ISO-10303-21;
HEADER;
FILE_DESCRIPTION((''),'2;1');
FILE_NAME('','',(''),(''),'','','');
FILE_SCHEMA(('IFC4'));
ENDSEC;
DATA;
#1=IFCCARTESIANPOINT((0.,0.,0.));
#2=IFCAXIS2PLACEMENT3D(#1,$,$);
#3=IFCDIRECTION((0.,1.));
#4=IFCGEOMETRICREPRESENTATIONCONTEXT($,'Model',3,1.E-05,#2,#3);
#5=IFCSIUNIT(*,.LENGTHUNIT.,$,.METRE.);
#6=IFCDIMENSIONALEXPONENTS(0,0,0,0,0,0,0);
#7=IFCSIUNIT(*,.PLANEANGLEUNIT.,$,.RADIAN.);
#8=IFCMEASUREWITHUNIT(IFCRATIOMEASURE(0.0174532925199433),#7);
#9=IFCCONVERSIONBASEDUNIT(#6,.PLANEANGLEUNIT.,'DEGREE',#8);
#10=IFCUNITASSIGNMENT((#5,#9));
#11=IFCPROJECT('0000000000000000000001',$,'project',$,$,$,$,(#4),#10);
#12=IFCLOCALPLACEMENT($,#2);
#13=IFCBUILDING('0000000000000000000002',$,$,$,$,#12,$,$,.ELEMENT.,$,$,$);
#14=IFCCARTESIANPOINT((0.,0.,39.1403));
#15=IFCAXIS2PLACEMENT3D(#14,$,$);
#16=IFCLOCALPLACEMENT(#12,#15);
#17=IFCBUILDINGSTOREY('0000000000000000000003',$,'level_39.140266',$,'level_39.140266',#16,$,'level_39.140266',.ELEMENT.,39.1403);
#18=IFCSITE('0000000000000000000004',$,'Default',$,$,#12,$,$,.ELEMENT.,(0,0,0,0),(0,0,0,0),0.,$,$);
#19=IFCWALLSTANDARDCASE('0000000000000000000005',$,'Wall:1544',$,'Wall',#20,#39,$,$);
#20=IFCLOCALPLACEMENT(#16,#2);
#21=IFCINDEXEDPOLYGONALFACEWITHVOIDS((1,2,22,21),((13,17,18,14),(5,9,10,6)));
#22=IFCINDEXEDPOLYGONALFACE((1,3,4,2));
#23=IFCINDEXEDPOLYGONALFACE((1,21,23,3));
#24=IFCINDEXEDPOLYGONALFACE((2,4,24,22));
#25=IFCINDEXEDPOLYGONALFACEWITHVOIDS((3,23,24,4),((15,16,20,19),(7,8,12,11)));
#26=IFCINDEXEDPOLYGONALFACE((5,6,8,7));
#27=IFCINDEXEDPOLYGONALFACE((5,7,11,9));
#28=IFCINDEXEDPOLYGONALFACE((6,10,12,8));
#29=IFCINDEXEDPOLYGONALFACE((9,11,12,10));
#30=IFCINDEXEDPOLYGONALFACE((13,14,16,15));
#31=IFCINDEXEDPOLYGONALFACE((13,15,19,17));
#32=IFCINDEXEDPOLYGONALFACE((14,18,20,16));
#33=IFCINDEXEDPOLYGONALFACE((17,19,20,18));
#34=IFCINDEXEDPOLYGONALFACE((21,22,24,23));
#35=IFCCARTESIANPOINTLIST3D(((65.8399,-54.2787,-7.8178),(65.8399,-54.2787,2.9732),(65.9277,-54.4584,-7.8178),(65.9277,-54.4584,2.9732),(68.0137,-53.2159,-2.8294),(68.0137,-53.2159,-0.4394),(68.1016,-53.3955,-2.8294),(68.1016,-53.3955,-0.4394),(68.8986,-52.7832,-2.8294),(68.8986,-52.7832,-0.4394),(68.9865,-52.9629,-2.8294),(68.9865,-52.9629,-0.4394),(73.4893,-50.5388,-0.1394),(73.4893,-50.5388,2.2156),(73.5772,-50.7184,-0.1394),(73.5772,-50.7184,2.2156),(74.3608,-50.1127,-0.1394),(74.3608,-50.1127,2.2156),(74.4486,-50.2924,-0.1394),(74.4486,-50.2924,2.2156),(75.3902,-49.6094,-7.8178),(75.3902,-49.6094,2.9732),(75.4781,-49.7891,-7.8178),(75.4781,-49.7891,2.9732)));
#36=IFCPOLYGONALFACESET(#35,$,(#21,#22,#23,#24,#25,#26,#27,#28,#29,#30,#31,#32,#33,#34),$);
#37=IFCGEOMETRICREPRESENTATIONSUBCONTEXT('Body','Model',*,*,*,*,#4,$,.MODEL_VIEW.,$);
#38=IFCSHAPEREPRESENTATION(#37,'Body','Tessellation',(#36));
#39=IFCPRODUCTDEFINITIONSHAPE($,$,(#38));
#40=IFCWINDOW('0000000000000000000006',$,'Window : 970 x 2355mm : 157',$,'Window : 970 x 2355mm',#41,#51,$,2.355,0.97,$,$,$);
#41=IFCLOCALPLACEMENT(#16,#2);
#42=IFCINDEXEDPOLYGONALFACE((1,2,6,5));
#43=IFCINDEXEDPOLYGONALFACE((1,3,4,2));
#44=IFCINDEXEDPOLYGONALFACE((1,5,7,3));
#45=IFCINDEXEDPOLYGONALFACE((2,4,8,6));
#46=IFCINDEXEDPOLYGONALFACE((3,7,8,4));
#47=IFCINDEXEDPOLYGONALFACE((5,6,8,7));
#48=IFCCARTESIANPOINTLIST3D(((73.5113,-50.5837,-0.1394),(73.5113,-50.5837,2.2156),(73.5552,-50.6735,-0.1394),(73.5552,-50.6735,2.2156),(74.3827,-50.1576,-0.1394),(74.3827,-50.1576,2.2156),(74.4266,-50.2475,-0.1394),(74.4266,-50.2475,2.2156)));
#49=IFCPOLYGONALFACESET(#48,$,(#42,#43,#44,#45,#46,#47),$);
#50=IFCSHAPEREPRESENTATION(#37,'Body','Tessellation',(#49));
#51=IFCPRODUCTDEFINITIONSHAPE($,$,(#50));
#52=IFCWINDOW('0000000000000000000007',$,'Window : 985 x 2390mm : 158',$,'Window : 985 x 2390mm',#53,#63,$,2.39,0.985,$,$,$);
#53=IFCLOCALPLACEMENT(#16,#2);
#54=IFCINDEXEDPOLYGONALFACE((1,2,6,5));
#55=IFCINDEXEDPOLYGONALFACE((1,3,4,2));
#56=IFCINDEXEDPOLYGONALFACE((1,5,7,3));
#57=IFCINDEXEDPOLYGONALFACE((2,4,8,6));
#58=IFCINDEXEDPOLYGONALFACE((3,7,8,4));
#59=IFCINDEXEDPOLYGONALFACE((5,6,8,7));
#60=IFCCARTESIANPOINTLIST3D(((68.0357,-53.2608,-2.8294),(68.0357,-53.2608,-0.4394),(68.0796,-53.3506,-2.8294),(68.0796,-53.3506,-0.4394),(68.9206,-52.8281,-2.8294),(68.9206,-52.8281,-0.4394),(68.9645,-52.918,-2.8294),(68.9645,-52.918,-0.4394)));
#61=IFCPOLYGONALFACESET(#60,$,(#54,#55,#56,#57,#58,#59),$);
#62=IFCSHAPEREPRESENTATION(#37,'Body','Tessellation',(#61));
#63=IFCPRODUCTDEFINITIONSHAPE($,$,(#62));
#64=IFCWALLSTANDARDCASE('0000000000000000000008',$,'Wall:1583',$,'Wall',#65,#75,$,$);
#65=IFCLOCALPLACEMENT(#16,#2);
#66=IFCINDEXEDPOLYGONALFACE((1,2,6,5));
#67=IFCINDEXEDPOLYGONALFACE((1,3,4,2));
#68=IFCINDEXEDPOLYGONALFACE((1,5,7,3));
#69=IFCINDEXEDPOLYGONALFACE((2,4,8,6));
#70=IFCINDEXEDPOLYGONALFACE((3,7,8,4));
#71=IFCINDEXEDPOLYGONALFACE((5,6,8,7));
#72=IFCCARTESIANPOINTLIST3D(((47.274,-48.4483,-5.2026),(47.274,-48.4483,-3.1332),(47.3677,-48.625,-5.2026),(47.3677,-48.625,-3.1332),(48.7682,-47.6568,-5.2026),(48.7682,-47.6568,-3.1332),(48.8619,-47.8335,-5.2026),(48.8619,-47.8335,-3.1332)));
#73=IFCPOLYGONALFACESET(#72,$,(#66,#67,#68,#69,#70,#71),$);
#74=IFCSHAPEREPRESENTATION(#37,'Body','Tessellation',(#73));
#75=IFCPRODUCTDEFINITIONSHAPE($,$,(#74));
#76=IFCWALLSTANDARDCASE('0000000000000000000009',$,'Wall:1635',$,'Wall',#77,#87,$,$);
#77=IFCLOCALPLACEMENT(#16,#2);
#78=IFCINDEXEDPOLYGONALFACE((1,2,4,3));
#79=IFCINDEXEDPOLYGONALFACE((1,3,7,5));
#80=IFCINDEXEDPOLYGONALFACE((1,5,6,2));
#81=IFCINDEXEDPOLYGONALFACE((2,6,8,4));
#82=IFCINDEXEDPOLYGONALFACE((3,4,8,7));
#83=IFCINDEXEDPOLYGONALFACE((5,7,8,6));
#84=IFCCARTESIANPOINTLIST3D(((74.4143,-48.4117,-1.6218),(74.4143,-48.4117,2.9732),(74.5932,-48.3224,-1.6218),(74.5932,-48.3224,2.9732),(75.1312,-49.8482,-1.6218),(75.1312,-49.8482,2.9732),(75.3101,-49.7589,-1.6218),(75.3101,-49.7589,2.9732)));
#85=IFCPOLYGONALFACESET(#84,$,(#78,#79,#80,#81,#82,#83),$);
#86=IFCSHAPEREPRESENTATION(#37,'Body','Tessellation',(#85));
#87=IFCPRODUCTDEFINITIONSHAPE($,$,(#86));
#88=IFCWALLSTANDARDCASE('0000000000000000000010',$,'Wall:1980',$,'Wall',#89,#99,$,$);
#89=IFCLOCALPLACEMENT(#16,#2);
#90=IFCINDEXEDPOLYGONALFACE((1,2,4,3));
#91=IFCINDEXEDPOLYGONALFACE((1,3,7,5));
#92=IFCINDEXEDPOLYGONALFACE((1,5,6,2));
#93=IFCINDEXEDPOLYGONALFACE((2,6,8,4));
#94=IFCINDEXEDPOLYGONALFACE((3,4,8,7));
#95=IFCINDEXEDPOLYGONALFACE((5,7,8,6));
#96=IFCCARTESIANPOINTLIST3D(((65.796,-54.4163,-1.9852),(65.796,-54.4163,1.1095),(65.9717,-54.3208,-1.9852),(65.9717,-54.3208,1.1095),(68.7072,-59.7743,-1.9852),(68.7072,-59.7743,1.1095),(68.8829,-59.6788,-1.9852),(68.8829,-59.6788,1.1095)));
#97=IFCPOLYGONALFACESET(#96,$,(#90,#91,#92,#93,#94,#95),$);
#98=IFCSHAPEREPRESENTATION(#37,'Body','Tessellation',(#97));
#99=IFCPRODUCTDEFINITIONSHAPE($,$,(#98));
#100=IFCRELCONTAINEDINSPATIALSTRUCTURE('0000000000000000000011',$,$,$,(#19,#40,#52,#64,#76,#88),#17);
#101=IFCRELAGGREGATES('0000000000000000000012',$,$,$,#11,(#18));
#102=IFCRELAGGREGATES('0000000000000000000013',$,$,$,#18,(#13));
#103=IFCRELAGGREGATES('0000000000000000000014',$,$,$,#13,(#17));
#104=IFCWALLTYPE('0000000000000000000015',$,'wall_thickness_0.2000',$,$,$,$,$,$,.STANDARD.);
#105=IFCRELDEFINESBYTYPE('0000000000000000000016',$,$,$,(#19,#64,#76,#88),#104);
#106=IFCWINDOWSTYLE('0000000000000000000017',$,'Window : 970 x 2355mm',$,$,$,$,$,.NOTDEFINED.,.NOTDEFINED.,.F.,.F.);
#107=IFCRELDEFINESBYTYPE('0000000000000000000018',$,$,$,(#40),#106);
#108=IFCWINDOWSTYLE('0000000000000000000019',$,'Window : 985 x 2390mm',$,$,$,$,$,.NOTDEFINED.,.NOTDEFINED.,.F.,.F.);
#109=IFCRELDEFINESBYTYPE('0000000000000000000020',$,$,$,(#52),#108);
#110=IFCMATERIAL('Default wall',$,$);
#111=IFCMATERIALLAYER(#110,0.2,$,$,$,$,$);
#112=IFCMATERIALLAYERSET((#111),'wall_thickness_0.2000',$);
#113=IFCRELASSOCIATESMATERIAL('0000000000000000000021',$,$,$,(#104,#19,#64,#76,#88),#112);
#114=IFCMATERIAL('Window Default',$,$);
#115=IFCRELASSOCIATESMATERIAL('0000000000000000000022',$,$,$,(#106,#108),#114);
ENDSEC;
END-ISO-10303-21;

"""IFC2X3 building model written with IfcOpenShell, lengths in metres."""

from ifc_helpers import new_model, entity, si_unit, converted_unit, direction, frame, frame_2d, origin, origin_2d_with_axis, place, context, subcontext, project, spatial, polyline, rectangle, outline, extrude, source, transform, mapped, material, layer, layer_set, layer_usage, type_object, type_shapes, element, fill, save


model = new_model("IFC2X3")

# Units and contexts
model_context = context("Model", 3, precision=1e-05, world=origin(), true_north=direction((0.0, 1.0)))
body_context = subcontext(model_context, "Body", "Model", "MODEL_VIEW")
ifc_project = project(units=[si_unit("LENGTHUNIT", "METRE"), converted_unit("PLANEANGLEUNIT", "DEGREE", entity("IfcRatioMeasure", 0.0174532925199433), si_unit("PLANEANGLEUNIT", "RADIAN"), dimensions=[0, 0, 0, 0, 0, 0, 0])], contexts=[model_context])

# Site, building, storey
placement_1 = place(None, origin())
site = spatial("IfcSite", under=ifc_project, at=placement_1, Name="Default", CompositionType="ELEMENT", RefLatitude=(0, 0, 0, 0), RefLongitude=(0, 0, 0, 0), RefElevation=0.0)
building = spatial("IfcBuilding", under=site, at=placement_1, CompositionType="ELEMENT")
storey_placement = place(placement_1, frame((0.0, 0.0, 39.1403)))
storey = spatial("IfcBuildingStorey", under=building, at=storey_placement, Name="level_39.140266", ObjectType="level_39.140266", LongName="level_39.140266", CompositionType="ELEMENT", Elevation=39.1403)

# Shared definitions
ifc_material_1 = material(Name="Default wall")
ifc_layer = layer(ifc_material_1, 0.2)
ifc_layer_set = layer_set([ifc_layer], Name="wall_thickness_0.2000")
ifc_layer_usage = layer_usage(ifc_layer_set, "AXIS2", "POSITIVE", -0.1)
wall_type = type_object("IfcWallType", Name="wall_thickness_0.2000", PredefinedType="STANDARD", material=ifc_layer_set)

# Wall, openings, windows
placement_2 = place(placement_1, frame((0.0, 0.0, 31.3225)))
wall_1_placement = place(placement_2, frame((65.8838, -54.3685, 0.0), z_axis=(0.0, 0.0, 1.0), x_axis=(0.898374, 0.439231, 0.0)))
wall_1 = element("IfcWallStandardCase", 1, at=wall_1_placement, inside=storey, type_object=wall_type, material=ifc_layer_usage, Name="Wall:1544", ObjectType="Wall", context=body_context, shape_type="SweptSolid", body=[
    extrude(outline(polyline([(10.6307, -0.1), (10.6307, 0.1), (0.0, 0.1), (0.0, -0.1), (10.6307, -0.1)])), origin(), (0.0, 0.0, 1.0), 10.791),
])
opening_1_placement = place(wall_1_placement, frame((8.5147, -0.1, 7.6783)))
opening_1 = element("IfcOpeningElement", 2, at=opening_1_placement, cuts=wall_1, ObjectType="Opening", context=body_context, shape_type="SweptSolid", body=[
    extrude(rectangle(XDim=0.97, YDim=2.355, at=frame_2d((1.1775, 0.485), x_axis=(0.0, 1.0))), frame((0.0, 0.0, 0.0), z_axis=(0.0, 1.0, 0.0), x_axis=(0.0, 0.0, 1.0)), (0.0, 0.0, 1.0), 0.2),
])
opening_2_placement = place(wall_1_placement, frame((2.4197, -0.1, 4.9883)))
opening_2 = element("IfcOpeningElement", 3, at=opening_2_placement, cuts=wall_1, ObjectType="Opening", context=body_context, shape_type="SweptSolid", body=[
    extrude(rectangle(XDim=0.985, YDim=2.39, at=frame_2d((1.195, 0.4925), x_axis=(0.0, 1.0))), frame((0.0, 0.0, 0.0), z_axis=(0.0, 1.0, 0.0), x_axis=(0.0, 0.0, 1.0)), (0.0, 0.0, 1.0), 0.2),
])
ifc_material_2 = material(Name="Window Default")
window_style_1 = type_object("IfcWindowStyle", Name="Window : 970 x 2355mm", ConstructionType="NOTDEFINED", OperationType="NOTDEFINED", ParameterTakesPrecedence=False, Sizeable=False, material=ifc_material_2)
shared_shape_1 = source(origin(), body_context, "Body", "SweptSolid", [
    extrude(rectangle(XDim=0.1, YDim=0.97, at=origin_2d_with_axis()), frame((0.485, 0.1, 0.0), z_axis=(0.0, 0.0, 1.0), x_axis=(0.0, 1.0, 0.0)), (0.0, 0.0, 1.0), 2.355),
])
type_shapes(window_style_1, [shared_shape_1])
window_1_placement = place(opening_1_placement, origin())
window_1 = element("IfcWindow", 4, at=window_1_placement, inside=storey, type_object=window_style_1, Name="Window : 970 x 2355mm : 157", ObjectType="Window : 970 x 2355mm", OverallHeight=2.355, OverallWidth=0.97, context=body_context, shape_type="MappedRepresentation", body=[
    mapped(shared_shape_1, transform((0.0, 0.0, 0.0), scale=1.0)),
])
fill(opening_1, window_1)
window_style_2 = type_object("IfcWindowStyle", Name="Window : 985 x 2390mm", ConstructionType="NOTDEFINED", OperationType="NOTDEFINED", ParameterTakesPrecedence=False, Sizeable=False, material=ifc_material_2)
shared_shape_2 = source(origin(), body_context, "Body", "SweptSolid", [
    extrude(rectangle(XDim=0.1, YDim=0.985, at=origin_2d_with_axis()), frame((0.4925, 0.1, 0.0), z_axis=(0.0, 0.0, 1.0), x_axis=(0.0, 1.0, 0.0)), (0.0, 0.0, 1.0), 2.39),
])
type_shapes(window_style_2, [shared_shape_2])
window_2_placement = place(opening_2_placement, origin())
window_2 = element("IfcWindow", 5, at=window_2_placement, inside=storey, type_object=window_style_2, Name="Window : 985 x 2390mm : 158", ObjectType="Window : 985 x 2390mm", OverallHeight=2.39, OverallWidth=0.985, context=body_context, shape_type="MappedRepresentation", body=[
    mapped(shared_shape_2, transform((0.0, 0.0, 0.0), scale=1.0)),
])
fill(opening_2, window_2)

# Walls
placement_3 = place(placement_1, frame((0.0, 0.0, 33.9377)))
wall_2_placement = place(placement_3, frame((48.815, -47.7452, 0.0), z_axis=(0.0, 0.0, 1.0), x_axis=(-0.883676, -0.468098, 0.0)))
element("IfcWallStandardCase", 6, at=wall_2_placement, inside=storey, type_object=wall_type, material=ifc_layer_usage, Name="Wall:1583", ObjectType="Wall", context=body_context, shape_type="SweptSolid", body=[
    extrude(outline(polyline([(1.6909, -0.1), (1.6909, 0.1), (0.0, 0.1), (0.0, -0.1), (1.6909, -0.1)])), origin(), (0.0, 0.0, 1.0), 2.0694),
])
placement_4 = place(placement_1, frame((0.0, 0.0, 37.5185)))
wall_3_placement = place(placement_4, frame((75.2207, -49.8036, 0.0), z_axis=(0.0, 0.0, 1.0), x_axis=(-0.446536, 0.894766, 0.0)))
element("IfcWallStandardCase", 7, at=wall_3_placement, inside=storey, type_object=wall_type, material=ifc_layer_usage, Name="Wall:1635", ObjectType="Wall", context=body_context, shape_type="SweptSolid", body=[
    extrude(outline(polyline([(1.6055, -0.1), (1.6055, 0.1), (0.0, 0.1), (0.0, -0.1), (1.6055, -0.1)])), origin(), (0.0, 0.0, 1.0), 4.595),
])
placement_5 = place(placement_1, frame((0.0, 0.0, 37.1551)))
wall_4_placement = place(placement_5, frame((65.8838, -54.3685, 0.0), z_axis=(0.0, 0.0, 1.0), x_axis=(0.477414, -0.878678, 0.0)))
element("IfcWallStandardCase", 8, at=wall_4_placement, inside=storey, type_object=wall_type, material=ifc_layer_usage, Name="Wall:1980", ObjectType="Wall", context=body_context, shape_type="SweptSolid", body=[
    extrude(outline(polyline([(6.0979, -0.1), (6.0979, 0.1), (0.0, 0.1), (0.0, -0.1), (6.0979, -0.1)])), origin(), (0.0, 0.0, 1.0), 3.0947),
])

save(model, "model.ifc")
